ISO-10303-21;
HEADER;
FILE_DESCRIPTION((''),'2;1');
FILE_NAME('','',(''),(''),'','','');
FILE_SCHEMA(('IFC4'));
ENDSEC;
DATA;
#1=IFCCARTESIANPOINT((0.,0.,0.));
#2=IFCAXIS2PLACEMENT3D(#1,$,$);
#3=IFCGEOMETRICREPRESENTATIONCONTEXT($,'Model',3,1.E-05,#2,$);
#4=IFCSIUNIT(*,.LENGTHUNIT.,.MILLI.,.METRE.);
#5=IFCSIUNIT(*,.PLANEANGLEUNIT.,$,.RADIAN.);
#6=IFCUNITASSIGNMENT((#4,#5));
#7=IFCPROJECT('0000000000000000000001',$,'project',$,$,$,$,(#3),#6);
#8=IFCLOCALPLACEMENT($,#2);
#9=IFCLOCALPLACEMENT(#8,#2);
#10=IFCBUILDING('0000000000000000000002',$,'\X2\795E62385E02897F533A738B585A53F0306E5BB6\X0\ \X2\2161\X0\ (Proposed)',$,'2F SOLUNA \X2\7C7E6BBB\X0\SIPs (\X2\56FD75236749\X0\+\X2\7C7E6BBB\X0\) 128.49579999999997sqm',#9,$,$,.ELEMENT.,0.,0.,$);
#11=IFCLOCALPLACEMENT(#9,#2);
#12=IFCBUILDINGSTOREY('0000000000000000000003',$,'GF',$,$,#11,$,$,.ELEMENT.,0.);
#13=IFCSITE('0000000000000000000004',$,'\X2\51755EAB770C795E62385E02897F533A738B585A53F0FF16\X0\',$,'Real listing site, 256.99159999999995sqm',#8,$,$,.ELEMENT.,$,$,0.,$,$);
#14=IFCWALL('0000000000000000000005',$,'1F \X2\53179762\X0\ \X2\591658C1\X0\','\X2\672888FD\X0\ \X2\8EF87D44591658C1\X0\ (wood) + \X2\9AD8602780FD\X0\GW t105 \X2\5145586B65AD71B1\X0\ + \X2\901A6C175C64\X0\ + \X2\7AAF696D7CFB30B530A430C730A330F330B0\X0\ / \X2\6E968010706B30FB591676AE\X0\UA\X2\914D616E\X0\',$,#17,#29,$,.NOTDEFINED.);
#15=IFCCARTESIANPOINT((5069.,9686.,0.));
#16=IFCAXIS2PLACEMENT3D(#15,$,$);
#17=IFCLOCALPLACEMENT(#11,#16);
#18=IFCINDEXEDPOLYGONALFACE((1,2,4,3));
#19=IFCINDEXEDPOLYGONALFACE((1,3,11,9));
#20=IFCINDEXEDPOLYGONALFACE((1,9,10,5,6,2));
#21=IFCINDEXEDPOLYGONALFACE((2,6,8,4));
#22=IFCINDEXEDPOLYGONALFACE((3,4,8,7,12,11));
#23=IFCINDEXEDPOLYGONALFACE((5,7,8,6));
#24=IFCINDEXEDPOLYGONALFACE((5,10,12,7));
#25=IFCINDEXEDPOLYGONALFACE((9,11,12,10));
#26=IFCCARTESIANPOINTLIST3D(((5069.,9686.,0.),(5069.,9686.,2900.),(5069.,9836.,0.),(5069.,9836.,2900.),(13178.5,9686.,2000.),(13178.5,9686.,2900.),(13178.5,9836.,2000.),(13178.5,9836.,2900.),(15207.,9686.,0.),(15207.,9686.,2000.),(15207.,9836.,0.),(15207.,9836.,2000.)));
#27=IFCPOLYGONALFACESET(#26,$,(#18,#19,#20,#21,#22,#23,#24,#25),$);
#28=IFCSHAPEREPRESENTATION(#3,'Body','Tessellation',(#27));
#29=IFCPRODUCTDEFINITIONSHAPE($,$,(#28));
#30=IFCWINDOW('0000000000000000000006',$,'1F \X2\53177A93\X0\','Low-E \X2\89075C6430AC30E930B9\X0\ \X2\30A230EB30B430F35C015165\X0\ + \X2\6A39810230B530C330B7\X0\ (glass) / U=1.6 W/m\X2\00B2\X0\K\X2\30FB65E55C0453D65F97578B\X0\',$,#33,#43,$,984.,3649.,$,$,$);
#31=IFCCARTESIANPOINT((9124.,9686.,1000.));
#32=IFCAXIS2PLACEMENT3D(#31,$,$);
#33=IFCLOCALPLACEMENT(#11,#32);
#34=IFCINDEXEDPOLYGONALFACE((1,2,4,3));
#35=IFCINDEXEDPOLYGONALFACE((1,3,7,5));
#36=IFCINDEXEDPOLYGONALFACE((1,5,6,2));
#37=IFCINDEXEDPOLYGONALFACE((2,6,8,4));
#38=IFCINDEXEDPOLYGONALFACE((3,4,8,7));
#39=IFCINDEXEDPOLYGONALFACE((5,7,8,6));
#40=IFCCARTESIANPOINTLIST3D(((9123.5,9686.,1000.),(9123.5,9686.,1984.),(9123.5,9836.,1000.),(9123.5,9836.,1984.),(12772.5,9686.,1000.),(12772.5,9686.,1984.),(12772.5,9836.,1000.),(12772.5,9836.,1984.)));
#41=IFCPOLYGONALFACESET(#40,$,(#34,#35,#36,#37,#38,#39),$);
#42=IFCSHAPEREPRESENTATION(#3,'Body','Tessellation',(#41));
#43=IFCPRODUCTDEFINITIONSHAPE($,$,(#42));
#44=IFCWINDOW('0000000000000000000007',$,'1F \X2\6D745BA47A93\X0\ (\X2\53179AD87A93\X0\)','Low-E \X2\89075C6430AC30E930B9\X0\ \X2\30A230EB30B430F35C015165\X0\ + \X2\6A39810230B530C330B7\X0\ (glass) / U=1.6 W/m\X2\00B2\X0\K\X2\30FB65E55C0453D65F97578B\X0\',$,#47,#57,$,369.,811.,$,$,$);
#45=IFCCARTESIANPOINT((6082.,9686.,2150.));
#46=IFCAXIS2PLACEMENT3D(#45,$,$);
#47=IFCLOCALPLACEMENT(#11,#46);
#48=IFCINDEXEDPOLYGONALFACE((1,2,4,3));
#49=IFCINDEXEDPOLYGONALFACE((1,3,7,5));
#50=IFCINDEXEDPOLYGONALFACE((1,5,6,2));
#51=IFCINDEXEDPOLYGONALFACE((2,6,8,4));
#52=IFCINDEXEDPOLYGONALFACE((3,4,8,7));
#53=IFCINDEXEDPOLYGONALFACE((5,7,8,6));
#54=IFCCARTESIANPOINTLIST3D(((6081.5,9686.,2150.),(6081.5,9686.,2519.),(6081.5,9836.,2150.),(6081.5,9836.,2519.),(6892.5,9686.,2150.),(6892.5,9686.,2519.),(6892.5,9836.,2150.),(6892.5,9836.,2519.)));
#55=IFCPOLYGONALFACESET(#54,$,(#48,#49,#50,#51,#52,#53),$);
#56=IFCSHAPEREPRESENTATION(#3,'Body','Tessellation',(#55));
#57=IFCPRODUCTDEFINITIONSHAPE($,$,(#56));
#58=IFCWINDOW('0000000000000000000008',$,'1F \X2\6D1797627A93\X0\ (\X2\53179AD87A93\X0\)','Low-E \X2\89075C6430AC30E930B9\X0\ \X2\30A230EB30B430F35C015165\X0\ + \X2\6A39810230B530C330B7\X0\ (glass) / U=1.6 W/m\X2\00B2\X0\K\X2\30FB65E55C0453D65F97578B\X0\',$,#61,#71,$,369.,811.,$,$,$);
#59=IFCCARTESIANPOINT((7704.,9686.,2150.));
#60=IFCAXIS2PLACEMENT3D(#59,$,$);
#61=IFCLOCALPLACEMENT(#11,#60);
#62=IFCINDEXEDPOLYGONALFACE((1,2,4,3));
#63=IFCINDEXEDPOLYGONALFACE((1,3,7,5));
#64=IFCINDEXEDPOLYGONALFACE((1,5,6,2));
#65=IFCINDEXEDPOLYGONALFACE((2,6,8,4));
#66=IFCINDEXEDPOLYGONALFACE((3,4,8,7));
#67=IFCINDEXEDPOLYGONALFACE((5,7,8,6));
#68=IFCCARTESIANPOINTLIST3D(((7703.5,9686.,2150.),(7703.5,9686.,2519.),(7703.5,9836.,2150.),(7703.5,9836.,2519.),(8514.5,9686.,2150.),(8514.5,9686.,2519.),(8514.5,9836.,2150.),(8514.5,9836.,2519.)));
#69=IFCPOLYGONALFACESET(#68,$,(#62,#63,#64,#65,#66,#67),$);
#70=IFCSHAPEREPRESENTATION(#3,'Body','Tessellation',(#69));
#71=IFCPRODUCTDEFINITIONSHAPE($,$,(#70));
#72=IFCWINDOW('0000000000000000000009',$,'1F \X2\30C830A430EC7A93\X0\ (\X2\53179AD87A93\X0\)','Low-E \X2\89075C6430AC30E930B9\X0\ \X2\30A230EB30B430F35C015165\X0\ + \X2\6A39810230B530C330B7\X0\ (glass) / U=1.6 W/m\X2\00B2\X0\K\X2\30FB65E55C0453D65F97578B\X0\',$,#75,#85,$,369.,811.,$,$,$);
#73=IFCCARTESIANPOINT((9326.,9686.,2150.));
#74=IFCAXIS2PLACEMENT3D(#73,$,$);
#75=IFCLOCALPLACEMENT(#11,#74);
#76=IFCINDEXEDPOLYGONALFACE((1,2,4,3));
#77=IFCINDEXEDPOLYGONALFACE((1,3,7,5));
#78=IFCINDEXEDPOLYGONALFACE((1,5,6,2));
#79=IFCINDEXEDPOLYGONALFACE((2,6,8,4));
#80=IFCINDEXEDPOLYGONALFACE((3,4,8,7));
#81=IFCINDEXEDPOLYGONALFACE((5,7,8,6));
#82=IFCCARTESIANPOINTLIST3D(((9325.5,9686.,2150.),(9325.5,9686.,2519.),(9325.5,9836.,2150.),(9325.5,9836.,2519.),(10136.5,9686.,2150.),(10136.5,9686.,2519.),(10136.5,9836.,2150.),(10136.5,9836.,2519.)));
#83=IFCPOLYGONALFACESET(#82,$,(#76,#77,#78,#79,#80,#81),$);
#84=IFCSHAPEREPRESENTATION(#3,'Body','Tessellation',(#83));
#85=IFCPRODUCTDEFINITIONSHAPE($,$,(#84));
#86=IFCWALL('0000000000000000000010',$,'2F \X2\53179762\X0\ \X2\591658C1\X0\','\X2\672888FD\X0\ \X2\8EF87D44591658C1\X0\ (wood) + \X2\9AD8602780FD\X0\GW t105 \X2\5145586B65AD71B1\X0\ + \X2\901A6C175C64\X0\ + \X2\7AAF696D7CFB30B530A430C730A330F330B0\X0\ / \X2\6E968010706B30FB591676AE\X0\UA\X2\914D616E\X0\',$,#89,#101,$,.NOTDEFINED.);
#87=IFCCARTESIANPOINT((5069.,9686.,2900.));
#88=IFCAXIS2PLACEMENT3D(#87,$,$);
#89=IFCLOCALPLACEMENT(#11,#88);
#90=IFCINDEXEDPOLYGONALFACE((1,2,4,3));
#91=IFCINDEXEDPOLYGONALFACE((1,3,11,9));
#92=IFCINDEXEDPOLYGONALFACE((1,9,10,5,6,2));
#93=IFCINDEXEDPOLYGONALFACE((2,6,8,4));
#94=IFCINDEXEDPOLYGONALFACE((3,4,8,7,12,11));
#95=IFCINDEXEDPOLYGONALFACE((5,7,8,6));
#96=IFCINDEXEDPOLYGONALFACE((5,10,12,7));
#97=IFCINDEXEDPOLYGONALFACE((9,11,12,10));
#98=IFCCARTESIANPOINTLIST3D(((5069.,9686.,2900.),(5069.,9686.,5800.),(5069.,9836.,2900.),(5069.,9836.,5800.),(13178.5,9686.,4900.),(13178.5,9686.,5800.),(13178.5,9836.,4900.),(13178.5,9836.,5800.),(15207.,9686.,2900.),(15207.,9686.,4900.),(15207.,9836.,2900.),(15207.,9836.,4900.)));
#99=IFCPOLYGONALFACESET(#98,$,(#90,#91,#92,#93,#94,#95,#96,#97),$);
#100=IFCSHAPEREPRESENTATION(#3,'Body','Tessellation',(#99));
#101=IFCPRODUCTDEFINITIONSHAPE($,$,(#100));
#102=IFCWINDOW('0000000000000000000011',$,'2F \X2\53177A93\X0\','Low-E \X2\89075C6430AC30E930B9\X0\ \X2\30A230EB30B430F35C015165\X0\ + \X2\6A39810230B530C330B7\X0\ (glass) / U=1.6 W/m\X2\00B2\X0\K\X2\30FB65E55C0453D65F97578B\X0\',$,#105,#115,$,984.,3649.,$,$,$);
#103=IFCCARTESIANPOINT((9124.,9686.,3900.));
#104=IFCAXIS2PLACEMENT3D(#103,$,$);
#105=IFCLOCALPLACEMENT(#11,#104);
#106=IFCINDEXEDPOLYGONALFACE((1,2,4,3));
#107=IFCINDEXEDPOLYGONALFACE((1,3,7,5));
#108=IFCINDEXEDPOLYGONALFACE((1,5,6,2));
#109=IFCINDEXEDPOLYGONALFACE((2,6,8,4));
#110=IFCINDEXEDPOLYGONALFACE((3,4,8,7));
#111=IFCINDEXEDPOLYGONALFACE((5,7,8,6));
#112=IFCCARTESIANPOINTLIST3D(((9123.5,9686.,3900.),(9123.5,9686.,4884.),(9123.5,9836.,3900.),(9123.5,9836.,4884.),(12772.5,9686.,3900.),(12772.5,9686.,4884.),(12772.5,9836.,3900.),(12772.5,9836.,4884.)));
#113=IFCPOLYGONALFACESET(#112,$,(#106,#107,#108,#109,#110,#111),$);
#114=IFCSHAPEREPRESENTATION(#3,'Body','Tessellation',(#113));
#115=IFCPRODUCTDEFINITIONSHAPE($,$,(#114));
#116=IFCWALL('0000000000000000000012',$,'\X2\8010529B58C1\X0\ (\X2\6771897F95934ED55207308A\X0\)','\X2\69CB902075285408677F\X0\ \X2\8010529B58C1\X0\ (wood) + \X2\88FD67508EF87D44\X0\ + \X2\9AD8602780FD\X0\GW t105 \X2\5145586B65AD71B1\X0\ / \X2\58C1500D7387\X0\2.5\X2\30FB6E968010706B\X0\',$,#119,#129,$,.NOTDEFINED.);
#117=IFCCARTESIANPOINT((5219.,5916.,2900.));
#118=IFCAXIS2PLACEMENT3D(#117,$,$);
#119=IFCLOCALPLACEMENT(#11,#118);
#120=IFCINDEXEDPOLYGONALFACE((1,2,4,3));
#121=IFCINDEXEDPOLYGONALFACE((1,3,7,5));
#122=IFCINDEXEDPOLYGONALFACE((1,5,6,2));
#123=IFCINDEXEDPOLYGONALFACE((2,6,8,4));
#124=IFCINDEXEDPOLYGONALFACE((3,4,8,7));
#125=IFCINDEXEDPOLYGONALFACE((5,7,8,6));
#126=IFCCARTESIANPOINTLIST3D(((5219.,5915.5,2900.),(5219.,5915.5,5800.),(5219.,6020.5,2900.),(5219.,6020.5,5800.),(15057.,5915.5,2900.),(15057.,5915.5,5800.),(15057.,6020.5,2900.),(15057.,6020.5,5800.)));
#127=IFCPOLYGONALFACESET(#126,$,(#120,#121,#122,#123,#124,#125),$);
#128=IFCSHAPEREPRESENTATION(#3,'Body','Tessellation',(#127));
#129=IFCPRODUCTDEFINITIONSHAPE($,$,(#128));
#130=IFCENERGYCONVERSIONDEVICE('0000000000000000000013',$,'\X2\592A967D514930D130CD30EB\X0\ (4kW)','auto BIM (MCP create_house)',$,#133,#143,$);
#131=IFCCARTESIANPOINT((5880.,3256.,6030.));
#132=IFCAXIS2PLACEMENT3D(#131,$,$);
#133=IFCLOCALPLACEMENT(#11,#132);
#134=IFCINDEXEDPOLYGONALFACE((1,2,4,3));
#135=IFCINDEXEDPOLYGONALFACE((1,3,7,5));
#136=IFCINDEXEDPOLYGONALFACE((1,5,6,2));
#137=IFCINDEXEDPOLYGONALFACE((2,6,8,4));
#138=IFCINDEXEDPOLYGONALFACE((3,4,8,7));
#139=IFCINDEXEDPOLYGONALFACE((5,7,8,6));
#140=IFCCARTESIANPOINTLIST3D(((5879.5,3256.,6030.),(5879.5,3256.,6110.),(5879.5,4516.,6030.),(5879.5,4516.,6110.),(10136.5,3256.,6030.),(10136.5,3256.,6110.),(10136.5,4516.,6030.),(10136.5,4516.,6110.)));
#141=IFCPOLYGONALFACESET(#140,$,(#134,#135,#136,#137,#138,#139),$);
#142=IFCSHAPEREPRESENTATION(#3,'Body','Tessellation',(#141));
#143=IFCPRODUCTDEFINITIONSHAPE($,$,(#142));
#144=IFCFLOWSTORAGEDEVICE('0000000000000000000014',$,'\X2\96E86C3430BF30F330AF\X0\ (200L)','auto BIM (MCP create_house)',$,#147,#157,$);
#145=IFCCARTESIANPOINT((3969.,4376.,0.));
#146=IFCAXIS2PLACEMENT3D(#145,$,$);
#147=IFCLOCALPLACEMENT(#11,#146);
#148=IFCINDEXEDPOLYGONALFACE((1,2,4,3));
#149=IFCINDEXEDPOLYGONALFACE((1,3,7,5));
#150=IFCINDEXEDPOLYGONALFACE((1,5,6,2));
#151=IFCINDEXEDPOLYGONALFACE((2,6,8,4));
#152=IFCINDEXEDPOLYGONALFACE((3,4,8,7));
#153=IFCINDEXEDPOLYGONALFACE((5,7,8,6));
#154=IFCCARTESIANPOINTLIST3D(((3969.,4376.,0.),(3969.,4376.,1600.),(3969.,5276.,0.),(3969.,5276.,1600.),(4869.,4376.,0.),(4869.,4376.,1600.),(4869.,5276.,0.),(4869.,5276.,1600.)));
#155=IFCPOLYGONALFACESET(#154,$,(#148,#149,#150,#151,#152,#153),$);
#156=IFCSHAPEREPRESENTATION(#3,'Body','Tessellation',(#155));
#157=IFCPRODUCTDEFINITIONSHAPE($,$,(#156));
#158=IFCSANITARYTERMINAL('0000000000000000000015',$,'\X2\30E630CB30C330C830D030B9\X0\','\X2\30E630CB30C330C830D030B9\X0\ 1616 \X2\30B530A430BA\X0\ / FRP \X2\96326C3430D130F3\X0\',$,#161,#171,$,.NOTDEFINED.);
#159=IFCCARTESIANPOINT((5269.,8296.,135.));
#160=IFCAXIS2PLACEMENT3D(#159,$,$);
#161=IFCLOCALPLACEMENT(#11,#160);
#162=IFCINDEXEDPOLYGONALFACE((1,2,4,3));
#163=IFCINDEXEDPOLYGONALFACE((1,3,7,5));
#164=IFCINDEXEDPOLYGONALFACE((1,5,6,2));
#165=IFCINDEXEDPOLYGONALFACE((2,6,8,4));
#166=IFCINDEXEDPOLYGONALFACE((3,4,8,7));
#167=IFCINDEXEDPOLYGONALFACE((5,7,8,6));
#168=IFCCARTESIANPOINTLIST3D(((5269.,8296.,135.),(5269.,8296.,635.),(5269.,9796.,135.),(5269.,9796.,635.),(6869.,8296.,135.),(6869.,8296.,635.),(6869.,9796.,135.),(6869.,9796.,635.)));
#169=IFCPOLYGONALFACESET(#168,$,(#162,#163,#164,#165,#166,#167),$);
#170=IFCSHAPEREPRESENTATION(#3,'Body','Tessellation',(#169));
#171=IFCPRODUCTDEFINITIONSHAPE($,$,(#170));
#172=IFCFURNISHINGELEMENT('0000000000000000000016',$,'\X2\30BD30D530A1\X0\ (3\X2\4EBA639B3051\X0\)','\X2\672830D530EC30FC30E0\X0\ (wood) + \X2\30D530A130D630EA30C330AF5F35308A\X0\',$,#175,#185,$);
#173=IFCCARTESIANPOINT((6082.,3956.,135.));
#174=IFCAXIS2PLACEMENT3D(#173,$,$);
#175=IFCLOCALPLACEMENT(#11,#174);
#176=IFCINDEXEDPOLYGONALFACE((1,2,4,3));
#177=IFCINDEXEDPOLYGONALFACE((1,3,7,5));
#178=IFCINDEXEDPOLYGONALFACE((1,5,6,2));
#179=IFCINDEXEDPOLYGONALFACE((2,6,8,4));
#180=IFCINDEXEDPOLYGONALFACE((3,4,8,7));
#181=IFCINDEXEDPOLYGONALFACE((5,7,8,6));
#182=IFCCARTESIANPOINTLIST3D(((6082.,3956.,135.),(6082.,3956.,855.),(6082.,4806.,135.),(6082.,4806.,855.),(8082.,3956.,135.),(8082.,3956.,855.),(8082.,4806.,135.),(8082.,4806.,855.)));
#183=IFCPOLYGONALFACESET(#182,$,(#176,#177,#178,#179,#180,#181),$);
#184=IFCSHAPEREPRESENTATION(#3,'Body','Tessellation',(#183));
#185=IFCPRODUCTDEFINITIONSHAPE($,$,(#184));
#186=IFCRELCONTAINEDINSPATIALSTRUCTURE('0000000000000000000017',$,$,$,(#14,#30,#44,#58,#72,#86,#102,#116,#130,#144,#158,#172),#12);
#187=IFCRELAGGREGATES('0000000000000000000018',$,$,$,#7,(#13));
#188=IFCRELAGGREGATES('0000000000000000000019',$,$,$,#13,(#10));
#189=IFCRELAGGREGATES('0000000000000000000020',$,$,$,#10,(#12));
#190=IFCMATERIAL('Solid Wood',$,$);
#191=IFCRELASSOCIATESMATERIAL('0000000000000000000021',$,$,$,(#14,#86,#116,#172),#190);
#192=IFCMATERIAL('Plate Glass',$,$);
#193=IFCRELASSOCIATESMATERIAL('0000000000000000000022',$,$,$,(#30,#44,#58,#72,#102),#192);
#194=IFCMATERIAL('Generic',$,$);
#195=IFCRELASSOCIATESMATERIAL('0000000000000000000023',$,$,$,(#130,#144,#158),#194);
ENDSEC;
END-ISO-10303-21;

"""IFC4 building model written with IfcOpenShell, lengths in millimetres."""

from ifc_helpers import new_model, si_unit, frame, frame_2d, origin, place, context, project, spatial, rectangle, extrude, material, element, fill, save


model = new_model("IFC4")

# Units and contexts
model_context = context("Model", 3, precision=1e-05, world=origin())
ifc_project = project(units=[si_unit("LENGTHUNIT", "METRE", prefix="MILLI"), si_unit("PLANEANGLEUNIT", "RADIAN")], contexts=[model_context])

# Site, building, storey
site_placement = place(None, origin())
site = spatial("IfcSite", under=ifc_project, at=site_placement, Name="兵庫県神戸市西区王塚台６", ObjectType="Real listing site, 256.99159999999995sqm", CompositionType="ELEMENT", RefElevation=0.0)
building_placement = place(site_placement, origin())
building = spatial("IfcBuilding", under=site, at=building_placement, Name="神戸市西区王塚台の家 Ⅱ (Proposed)", ObjectType="2F SOLUNA 籾殻SIPs (国産杉+籾殻) 128.49579999999997sqm", CompositionType="ELEMENT", ElevationOfRefHeight=0.0, ElevationOfTerrain=0.0)
storey_placement = place(building_placement, origin())
storey = spatial("IfcBuildingStorey", under=building, at=storey_placement, Name="GF", CompositionType="ELEMENT", Elevation=0.0)

# Wall, openings, windows
ifc_material_1 = material(Name="Solid Wood")
wall_1_placement = place(storey_placement, frame((5069.0, 9686.0, 0.0)))
wall_1 = element("IfcWall", 1, at=wall_1_placement, inside=storey, material=ifc_material_1, Name="1F 北面 外壁", Description="木製 軸組外壁 (wood) + 高性能GW t105 充填断熱 + 通気層 + 窯業系サイディング / 準耐火・外皮UA配慮", PredefinedType="NOTDEFINED", context=model_context, shape_type="SweptSolid", body=[
    extrude(rectangle(XDim=10138.0, YDim=150.0, at=frame_2d((5069.0, 75.0))), frame((5069.0, 9686.0, 0.0)), (0.0, 0.0, 1.0), 2900.0),
])
opening_1_placement = place(storey_placement, frame((9124.0, 9686.0, 1000.0)))
opening_1 = element("IfcOpeningElement", 2, at=opening_1_placement, cuts=wall_1, PredefinedType="NOTDEFINED", context=model_context, shape_type="SweptSolid", body=[
    extrude(rectangle(XDim=3649.0, YDim=150.0, at=frame_2d((1824.0, 75.0))), frame((9124.0, 9686.0, 1000.0)), (0.0, 0.0, 1.0), 984.0),
])
opening_2_placement = place(storey_placement, frame((6082.0, 9686.0, 2150.0)))
opening_2 = element("IfcOpeningElement", 3, at=opening_2_placement, cuts=wall_1, PredefinedType="NOTDEFINED", context=model_context, shape_type="SweptSolid", body=[
    extrude(rectangle(XDim=811.0, YDim=150.0, at=frame_2d((405.0, 75.0))), frame((6082.0, 9686.0, 2150.0)), (0.0, 0.0, 1.0), 369.0),
])
opening_3_placement = place(storey_placement, frame((7704.0, 9686.0, 2150.0)))
opening_3 = element("IfcOpeningElement", 4, at=opening_3_placement, cuts=wall_1, PredefinedType="NOTDEFINED", context=model_context, shape_type="SweptSolid", body=[
    extrude(rectangle(XDim=811.0, YDim=150.0, at=frame_2d((405.0, 75.0))), frame((7704.0, 9686.0, 2150.0)), (0.0, 0.0, 1.0), 369.0),
])
opening_4_placement = place(storey_placement, frame((9326.0, 9686.0, 2150.0)))
opening_4 = element("IfcOpeningElement", 5, at=opening_4_placement, cuts=wall_1, PredefinedType="NOTDEFINED", context=model_context, shape_type="SweptSolid", body=[
    extrude(rectangle(XDim=811.0, YDim=150.0, at=frame_2d((405.0, 75.0))), frame((9326.0, 9686.0, 2150.0)), (0.0, 0.0, 1.0), 369.0),
])
ifc_material_2 = material(Name="Plate Glass")
window_1_placement = place(storey_placement, frame((9124.0, 9686.0, 1000.0)))
window_1 = element("IfcWindow", 6, at=window_1_placement, inside=storey, material=ifc_material_2, Name="1F 北窓", Description="Low-E 複層ガラス アルゴン封入 + 樹脂サッシ (glass) / U=1.6 W/m²K・日射取得型", OverallHeight=984.0, OverallWidth=3649.0, context=model_context, shape_type="SweptSolid", body=[
    extrude(rectangle(XDim=3649.0, YDim=150.0, at=frame_2d((1824.0, 75.0))), frame((9124.0, 9686.0, 1000.0)), (0.0, 0.0, 1.0), 984.0),
])
fill(opening_1, window_1)
window_2_placement = place(storey_placement, frame((6082.0, 9686.0, 2150.0)))
window_2 = element("IfcWindow", 7, at=window_2_placement, inside=storey, material=ifc_material_2, Name="1F 浴室窓 (北高窓)", Description="Low-E 複層ガラス アルゴン封入 + 樹脂サッシ (glass) / U=1.6 W/m²K・日射取得型", OverallHeight=369.0, OverallWidth=811.0, context=model_context, shape_type="SweptSolid", body=[
    extrude(rectangle(XDim=811.0, YDim=150.0, at=frame_2d((405.0, 75.0))), frame((6082.0, 9686.0, 2150.0)), (0.0, 0.0, 1.0), 369.0),
])
fill(opening_2, window_2)
window_3_placement = place(storey_placement, frame((7704.0, 9686.0, 2150.0)))
window_3 = element("IfcWindow", 8, at=window_3_placement, inside=storey, material=ifc_material_2, Name="1F 洗面窓 (北高窓)", Description="Low-E 複層ガラス アルゴン封入 + 樹脂サッシ (glass) / U=1.6 W/m²K・日射取得型", OverallHeight=369.0, OverallWidth=811.0, context=model_context, shape_type="SweptSolid", body=[
    extrude(rectangle(XDim=811.0, YDim=150.0, at=frame_2d((405.0, 75.0))), frame((7704.0, 9686.0, 2150.0)), (0.0, 0.0, 1.0), 369.0),
])
fill(opening_3, window_3)
window_4_placement = place(storey_placement, frame((9326.0, 9686.0, 2150.0)))
window_4 = element("IfcWindow", 9, at=window_4_placement, inside=storey, material=ifc_material_2, Name="1F トイレ窓 (北高窓)", Description="Low-E 複層ガラス アルゴン封入 + 樹脂サッシ (glass) / U=1.6 W/m²K・日射取得型", OverallHeight=369.0, OverallWidth=811.0, context=model_context, shape_type="SweptSolid", body=[
    extrude(rectangle(XDim=811.0, YDim=150.0, at=frame_2d((405.0, 75.0))), frame((9326.0, 9686.0, 2150.0)), (0.0, 0.0, 1.0), 369.0),
])
fill(opening_4, window_4)

# Wall, opening, window
wall_2_placement = place(storey_placement, frame((5069.0, 9686.0, 2900.0)))
wall_2 = element("IfcWall", 10, at=wall_2_placement, inside=storey, material=ifc_material_1, Name="2F 北面 外壁", Description="木製 軸組外壁 (wood) + 高性能GW t105 充填断熱 + 通気層 + 窯業系サイディング / 準耐火・外皮UA配慮", PredefinedType="NOTDEFINED", context=model_context, shape_type="SweptSolid", body=[
    extrude(rectangle(XDim=10138.0, YDim=150.0, at=frame_2d((5069.0, 75.0))), frame((5069.0, 9686.0, 2900.0)), (0.0, 0.0, 1.0), 2900.0),
])
opening_5_placement = place(storey_placement, frame((9124.0, 9686.0, 3900.0)))
opening_5 = element("IfcOpeningElement", 11, at=opening_5_placement, cuts=wall_2, PredefinedType="NOTDEFINED", context=model_context, shape_type="SweptSolid", body=[
    extrude(rectangle(XDim=3649.0, YDim=150.0, at=frame_2d((1824.0, 75.0))), frame((9124.0, 9686.0, 3900.0)), (0.0, 0.0, 1.0), 984.0),
])
window_5_placement = place(storey_placement, frame((9124.0, 9686.0, 3900.0)))
window_5 = element("IfcWindow", 12, at=window_5_placement, inside=storey, material=ifc_material_2, Name="2F 北窓", Description="Low-E 複層ガラス アルゴン封入 + 樹脂サッシ (glass) / U=1.6 W/m²K・日射取得型", OverallHeight=984.0, OverallWidth=3649.0, context=model_context, shape_type="SweptSolid", body=[
    extrude(rectangle(XDim=3649.0, YDim=150.0, at=frame_2d((1824.0, 75.0))), frame((9124.0, 9686.0, 3900.0)), (0.0, 0.0, 1.0), 984.0),
])
fill(opening_5, window_5)

# Wall
wall_3_placement = place(storey_placement, frame((5219.0, 5916.0, 2900.0)))
element("IfcWall", 13, at=wall_3_placement, inside=storey, material=ifc_material_1, Name="耐力壁 (東西間仕切り)", Description="構造用合板 耐力壁 (wood) + 製材軸組 + 高性能GW t105 充填断熱 / 壁倍率2.5・準耐火", PredefinedType="NOTDEFINED", context=model_context, shape_type="SweptSolid", body=[
    extrude(rectangle(XDim=9838.0, YDim=105.0, at=frame_2d((4919.0, 52.0))), frame((5219.0, 5916.0, 2900.0)), (0.0, 0.0, 1.0), 2900.0),
])

# Energy conversion device
ifc_material_3 = material(Name="Generic")
energy_conversion_device_placement = place(storey_placement, frame((5880.0, 3256.0, 6030.0)))
element("IfcEnergyConversionDevice", 14, at=energy_conversion_device_placement, inside=storey, material=ifc_material_3, Name="太陽光パネル (4kW)", Description="auto BIM (MCP create_house)", context=model_context, shape_type="SweptSolid", body=[
    extrude(rectangle(XDim=4257.0, YDim=1260.0, at=frame_2d((2128.0, 630.0))), frame((5880.0, 3256.0, 6030.0)), (0.0, 0.0, 1.0), 80.0),
])

# Flow storage device
flow_storage_device_placement = place(storey_placement, frame((3969.0, 4376.0, 0.0)))
element("IfcFlowStorageDevice", 15, at=flow_storage_device_placement, inside=storey, material=ifc_material_3, Name="雨水タンク (200L)", Description="auto BIM (MCP create_house)", context=model_context, shape_type="SweptSolid", body=[
    extrude(rectangle(XDim=900.0, YDim=900.0, at=frame_2d((450.0, 450.0))), frame((3969.0, 4376.0, 0.0)), (0.0, 0.0, 1.0), 1600.0),
])

# Sanitary terminal
sanitary_terminal_placement = place(storey_placement, frame((5269.0, 8296.0, 135.0)))
element("IfcSanitaryTerminal", 16, at=sanitary_terminal_placement, inside=storey, material=ifc_material_3, Name="ユニットバス", Description="ユニットバス 1616 サイズ / FRP 防水パン", PredefinedType="NOTDEFINED", context=model_context, shape_type="SweptSolid", body=[
    extrude(rectangle(XDim=1600.0, YDim=1500.0, at=frame_2d((800.0, 750.0))), frame((5269.0, 8296.0, 135.0)), (0.0, 0.0, 1.0), 500.0),
])

# Furnishing element
furnishing_1_placement = place(storey_placement, frame((6082.0, 3956.0, 135.0)))
element("IfcFurnishingElement", 17, at=furnishing_1_placement, inside=storey, material=ifc_material_1, Name="ソファ (3人掛け)", Description="木フレーム (wood) + ファブリック張り", context=model_context, shape_type="SweptSolid", body=[
    extrude(rectangle(XDim=2000.0, YDim=850.0, at=frame_2d((1000.0, 425.0))), frame((6082.0, 3956.0, 135.0)), (0.0, 0.0, 1.0), 720.0),
])

save(model, "model.ifc")
